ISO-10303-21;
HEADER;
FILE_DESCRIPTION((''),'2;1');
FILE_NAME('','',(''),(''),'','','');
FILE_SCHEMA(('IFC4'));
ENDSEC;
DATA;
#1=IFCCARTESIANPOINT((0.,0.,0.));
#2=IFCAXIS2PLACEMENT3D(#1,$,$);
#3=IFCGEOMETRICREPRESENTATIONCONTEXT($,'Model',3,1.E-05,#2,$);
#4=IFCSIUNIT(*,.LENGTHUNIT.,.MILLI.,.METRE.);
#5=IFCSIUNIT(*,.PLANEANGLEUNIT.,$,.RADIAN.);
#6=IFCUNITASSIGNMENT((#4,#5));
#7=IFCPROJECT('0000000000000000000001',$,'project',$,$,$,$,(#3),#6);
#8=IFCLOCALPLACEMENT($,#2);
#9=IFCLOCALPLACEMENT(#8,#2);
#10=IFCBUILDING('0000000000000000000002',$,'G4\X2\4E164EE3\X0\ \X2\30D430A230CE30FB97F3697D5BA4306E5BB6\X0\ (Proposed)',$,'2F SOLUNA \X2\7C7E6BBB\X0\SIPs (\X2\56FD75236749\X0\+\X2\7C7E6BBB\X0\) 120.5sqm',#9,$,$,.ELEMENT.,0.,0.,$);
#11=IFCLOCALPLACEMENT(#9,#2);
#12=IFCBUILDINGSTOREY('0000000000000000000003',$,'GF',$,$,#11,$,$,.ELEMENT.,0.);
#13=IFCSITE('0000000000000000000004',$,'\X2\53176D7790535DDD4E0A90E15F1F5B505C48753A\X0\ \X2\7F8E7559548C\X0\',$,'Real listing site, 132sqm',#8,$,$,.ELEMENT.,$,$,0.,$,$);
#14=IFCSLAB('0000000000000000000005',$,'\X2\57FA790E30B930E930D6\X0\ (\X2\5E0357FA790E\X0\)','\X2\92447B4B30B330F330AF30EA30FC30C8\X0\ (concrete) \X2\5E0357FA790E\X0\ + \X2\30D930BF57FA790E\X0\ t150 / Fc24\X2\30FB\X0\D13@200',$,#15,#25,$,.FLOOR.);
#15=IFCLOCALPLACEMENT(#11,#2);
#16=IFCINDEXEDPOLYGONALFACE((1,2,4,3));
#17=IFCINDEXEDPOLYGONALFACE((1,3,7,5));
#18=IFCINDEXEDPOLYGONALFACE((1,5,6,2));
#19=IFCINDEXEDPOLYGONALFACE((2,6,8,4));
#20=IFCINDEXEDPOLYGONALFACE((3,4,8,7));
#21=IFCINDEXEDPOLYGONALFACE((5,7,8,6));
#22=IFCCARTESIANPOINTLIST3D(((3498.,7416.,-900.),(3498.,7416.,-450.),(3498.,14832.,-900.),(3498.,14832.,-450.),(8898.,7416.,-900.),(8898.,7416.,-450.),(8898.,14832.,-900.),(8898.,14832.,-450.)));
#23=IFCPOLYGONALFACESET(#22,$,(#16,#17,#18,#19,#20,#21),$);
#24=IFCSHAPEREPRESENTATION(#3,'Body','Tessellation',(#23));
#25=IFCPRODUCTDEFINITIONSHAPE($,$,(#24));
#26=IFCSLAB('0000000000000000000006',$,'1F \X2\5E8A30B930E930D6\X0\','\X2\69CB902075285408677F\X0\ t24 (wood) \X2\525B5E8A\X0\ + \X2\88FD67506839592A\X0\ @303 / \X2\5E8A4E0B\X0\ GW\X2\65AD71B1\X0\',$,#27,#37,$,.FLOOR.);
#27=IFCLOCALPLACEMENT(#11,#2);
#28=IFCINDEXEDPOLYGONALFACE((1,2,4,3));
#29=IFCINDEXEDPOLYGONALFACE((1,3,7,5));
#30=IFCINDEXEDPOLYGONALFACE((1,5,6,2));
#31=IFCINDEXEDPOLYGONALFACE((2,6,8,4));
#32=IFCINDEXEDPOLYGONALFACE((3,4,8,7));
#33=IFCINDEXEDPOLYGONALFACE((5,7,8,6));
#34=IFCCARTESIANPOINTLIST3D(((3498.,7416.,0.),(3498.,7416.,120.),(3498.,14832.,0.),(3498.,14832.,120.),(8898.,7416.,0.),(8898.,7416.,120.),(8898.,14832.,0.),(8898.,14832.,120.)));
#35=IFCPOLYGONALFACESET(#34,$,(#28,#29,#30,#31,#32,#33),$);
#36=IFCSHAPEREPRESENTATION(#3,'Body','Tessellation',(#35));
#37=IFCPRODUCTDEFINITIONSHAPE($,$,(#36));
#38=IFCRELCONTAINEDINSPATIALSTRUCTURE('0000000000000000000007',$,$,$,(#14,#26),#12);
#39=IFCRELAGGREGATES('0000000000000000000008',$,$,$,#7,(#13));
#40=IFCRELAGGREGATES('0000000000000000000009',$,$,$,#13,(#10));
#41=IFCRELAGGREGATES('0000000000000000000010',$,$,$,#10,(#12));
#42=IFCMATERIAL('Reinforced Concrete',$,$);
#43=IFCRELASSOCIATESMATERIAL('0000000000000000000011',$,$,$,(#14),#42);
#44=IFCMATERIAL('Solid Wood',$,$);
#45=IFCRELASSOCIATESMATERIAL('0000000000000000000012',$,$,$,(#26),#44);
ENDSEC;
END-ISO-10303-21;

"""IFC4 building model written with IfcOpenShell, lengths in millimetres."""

from ifc_helpers import new_model, si_unit, frame, frame_2d, origin, place, context, project, spatial, rectangle, extrude, material, element, save


model = new_model("IFC4")

# Units and contexts
model_context = context("Model", 3, precision=1e-05, world=origin())
ifc_project = project(units=[si_unit("LENGTHUNIT", "METRE", prefix="MILLI"), si_unit("PLANEANGLEUNIT", "RADIAN")], contexts=[model_context])

# Site, building, storey
site_placement = place(None, origin())
site = spatial("IfcSite", under=ifc_project, at=site_placement, Name="北海道川上郡弟子屈町 美留和", ObjectType="Real listing site, 132sqm", CompositionType="ELEMENT", RefElevation=0.0)
building_placement = place(site_placement, origin())
building = spatial("IfcBuilding", under=site, at=building_placement, Name="G4世代 ピアノ・音楽室の家 (Proposed)", ObjectType="2F SOLUNA 籾殻SIPs (国産杉+籾殻) 120.5sqm", CompositionType="ELEMENT", ElevationOfRefHeight=0.0, ElevationOfTerrain=0.0)
storey_placement = place(building_placement, origin())
storey = spatial("IfcBuildingStorey", under=building, at=storey_placement, Name="GF", CompositionType="ELEMENT", Elevation=0.0)

# Slabs
ifc_material_1 = material(Name="Reinforced Concrete")
slab_1_placement = place(storey_placement, frame((1749.0, 3708.0, -450.0)))
element("IfcSlab", 1, at=slab_1_placement, inside=storey, material=ifc_material_1, Name="基礎スラブ (布基礎)", Description="鉄筋コンクリート (concrete) 布基礎 + ベタ基礎 t150 / Fc24・D13@200", PredefinedType="FLOOR", context=model_context, shape_type="SweptSolid", body=[
    extrude(rectangle(XDim=5400.0, YDim=7416.0, at=frame_2d((2700.0, 3708.0))), frame((1749.0, 3708.0, -450.0)), (0.0, 0.0, 1.0), 450.0),
])
ifc_material_2 = material(Name="Solid Wood")
slab_2_placement = place(storey_placement, frame((1749.0, 3708.0, 0.0)))
element("IfcSlab", 2, at=slab_2_placement, inside=storey, material=ifc_material_2, Name="1F 床スラブ", Description="構造用合板 t24 (wood) 剛床 + 製材根太 @303 / 床下 GW断熱", PredefinedType="FLOOR", context=model_context, shape_type="SweptSolid", body=[
    extrude(rectangle(XDim=5400.0, YDim=7416.0, at=frame_2d((2700.0, 3708.0))), frame((1749.0, 3708.0, 0.0)), (0.0, 0.0, 1.0), 120.0),
])

save(model, "model.ifc")
